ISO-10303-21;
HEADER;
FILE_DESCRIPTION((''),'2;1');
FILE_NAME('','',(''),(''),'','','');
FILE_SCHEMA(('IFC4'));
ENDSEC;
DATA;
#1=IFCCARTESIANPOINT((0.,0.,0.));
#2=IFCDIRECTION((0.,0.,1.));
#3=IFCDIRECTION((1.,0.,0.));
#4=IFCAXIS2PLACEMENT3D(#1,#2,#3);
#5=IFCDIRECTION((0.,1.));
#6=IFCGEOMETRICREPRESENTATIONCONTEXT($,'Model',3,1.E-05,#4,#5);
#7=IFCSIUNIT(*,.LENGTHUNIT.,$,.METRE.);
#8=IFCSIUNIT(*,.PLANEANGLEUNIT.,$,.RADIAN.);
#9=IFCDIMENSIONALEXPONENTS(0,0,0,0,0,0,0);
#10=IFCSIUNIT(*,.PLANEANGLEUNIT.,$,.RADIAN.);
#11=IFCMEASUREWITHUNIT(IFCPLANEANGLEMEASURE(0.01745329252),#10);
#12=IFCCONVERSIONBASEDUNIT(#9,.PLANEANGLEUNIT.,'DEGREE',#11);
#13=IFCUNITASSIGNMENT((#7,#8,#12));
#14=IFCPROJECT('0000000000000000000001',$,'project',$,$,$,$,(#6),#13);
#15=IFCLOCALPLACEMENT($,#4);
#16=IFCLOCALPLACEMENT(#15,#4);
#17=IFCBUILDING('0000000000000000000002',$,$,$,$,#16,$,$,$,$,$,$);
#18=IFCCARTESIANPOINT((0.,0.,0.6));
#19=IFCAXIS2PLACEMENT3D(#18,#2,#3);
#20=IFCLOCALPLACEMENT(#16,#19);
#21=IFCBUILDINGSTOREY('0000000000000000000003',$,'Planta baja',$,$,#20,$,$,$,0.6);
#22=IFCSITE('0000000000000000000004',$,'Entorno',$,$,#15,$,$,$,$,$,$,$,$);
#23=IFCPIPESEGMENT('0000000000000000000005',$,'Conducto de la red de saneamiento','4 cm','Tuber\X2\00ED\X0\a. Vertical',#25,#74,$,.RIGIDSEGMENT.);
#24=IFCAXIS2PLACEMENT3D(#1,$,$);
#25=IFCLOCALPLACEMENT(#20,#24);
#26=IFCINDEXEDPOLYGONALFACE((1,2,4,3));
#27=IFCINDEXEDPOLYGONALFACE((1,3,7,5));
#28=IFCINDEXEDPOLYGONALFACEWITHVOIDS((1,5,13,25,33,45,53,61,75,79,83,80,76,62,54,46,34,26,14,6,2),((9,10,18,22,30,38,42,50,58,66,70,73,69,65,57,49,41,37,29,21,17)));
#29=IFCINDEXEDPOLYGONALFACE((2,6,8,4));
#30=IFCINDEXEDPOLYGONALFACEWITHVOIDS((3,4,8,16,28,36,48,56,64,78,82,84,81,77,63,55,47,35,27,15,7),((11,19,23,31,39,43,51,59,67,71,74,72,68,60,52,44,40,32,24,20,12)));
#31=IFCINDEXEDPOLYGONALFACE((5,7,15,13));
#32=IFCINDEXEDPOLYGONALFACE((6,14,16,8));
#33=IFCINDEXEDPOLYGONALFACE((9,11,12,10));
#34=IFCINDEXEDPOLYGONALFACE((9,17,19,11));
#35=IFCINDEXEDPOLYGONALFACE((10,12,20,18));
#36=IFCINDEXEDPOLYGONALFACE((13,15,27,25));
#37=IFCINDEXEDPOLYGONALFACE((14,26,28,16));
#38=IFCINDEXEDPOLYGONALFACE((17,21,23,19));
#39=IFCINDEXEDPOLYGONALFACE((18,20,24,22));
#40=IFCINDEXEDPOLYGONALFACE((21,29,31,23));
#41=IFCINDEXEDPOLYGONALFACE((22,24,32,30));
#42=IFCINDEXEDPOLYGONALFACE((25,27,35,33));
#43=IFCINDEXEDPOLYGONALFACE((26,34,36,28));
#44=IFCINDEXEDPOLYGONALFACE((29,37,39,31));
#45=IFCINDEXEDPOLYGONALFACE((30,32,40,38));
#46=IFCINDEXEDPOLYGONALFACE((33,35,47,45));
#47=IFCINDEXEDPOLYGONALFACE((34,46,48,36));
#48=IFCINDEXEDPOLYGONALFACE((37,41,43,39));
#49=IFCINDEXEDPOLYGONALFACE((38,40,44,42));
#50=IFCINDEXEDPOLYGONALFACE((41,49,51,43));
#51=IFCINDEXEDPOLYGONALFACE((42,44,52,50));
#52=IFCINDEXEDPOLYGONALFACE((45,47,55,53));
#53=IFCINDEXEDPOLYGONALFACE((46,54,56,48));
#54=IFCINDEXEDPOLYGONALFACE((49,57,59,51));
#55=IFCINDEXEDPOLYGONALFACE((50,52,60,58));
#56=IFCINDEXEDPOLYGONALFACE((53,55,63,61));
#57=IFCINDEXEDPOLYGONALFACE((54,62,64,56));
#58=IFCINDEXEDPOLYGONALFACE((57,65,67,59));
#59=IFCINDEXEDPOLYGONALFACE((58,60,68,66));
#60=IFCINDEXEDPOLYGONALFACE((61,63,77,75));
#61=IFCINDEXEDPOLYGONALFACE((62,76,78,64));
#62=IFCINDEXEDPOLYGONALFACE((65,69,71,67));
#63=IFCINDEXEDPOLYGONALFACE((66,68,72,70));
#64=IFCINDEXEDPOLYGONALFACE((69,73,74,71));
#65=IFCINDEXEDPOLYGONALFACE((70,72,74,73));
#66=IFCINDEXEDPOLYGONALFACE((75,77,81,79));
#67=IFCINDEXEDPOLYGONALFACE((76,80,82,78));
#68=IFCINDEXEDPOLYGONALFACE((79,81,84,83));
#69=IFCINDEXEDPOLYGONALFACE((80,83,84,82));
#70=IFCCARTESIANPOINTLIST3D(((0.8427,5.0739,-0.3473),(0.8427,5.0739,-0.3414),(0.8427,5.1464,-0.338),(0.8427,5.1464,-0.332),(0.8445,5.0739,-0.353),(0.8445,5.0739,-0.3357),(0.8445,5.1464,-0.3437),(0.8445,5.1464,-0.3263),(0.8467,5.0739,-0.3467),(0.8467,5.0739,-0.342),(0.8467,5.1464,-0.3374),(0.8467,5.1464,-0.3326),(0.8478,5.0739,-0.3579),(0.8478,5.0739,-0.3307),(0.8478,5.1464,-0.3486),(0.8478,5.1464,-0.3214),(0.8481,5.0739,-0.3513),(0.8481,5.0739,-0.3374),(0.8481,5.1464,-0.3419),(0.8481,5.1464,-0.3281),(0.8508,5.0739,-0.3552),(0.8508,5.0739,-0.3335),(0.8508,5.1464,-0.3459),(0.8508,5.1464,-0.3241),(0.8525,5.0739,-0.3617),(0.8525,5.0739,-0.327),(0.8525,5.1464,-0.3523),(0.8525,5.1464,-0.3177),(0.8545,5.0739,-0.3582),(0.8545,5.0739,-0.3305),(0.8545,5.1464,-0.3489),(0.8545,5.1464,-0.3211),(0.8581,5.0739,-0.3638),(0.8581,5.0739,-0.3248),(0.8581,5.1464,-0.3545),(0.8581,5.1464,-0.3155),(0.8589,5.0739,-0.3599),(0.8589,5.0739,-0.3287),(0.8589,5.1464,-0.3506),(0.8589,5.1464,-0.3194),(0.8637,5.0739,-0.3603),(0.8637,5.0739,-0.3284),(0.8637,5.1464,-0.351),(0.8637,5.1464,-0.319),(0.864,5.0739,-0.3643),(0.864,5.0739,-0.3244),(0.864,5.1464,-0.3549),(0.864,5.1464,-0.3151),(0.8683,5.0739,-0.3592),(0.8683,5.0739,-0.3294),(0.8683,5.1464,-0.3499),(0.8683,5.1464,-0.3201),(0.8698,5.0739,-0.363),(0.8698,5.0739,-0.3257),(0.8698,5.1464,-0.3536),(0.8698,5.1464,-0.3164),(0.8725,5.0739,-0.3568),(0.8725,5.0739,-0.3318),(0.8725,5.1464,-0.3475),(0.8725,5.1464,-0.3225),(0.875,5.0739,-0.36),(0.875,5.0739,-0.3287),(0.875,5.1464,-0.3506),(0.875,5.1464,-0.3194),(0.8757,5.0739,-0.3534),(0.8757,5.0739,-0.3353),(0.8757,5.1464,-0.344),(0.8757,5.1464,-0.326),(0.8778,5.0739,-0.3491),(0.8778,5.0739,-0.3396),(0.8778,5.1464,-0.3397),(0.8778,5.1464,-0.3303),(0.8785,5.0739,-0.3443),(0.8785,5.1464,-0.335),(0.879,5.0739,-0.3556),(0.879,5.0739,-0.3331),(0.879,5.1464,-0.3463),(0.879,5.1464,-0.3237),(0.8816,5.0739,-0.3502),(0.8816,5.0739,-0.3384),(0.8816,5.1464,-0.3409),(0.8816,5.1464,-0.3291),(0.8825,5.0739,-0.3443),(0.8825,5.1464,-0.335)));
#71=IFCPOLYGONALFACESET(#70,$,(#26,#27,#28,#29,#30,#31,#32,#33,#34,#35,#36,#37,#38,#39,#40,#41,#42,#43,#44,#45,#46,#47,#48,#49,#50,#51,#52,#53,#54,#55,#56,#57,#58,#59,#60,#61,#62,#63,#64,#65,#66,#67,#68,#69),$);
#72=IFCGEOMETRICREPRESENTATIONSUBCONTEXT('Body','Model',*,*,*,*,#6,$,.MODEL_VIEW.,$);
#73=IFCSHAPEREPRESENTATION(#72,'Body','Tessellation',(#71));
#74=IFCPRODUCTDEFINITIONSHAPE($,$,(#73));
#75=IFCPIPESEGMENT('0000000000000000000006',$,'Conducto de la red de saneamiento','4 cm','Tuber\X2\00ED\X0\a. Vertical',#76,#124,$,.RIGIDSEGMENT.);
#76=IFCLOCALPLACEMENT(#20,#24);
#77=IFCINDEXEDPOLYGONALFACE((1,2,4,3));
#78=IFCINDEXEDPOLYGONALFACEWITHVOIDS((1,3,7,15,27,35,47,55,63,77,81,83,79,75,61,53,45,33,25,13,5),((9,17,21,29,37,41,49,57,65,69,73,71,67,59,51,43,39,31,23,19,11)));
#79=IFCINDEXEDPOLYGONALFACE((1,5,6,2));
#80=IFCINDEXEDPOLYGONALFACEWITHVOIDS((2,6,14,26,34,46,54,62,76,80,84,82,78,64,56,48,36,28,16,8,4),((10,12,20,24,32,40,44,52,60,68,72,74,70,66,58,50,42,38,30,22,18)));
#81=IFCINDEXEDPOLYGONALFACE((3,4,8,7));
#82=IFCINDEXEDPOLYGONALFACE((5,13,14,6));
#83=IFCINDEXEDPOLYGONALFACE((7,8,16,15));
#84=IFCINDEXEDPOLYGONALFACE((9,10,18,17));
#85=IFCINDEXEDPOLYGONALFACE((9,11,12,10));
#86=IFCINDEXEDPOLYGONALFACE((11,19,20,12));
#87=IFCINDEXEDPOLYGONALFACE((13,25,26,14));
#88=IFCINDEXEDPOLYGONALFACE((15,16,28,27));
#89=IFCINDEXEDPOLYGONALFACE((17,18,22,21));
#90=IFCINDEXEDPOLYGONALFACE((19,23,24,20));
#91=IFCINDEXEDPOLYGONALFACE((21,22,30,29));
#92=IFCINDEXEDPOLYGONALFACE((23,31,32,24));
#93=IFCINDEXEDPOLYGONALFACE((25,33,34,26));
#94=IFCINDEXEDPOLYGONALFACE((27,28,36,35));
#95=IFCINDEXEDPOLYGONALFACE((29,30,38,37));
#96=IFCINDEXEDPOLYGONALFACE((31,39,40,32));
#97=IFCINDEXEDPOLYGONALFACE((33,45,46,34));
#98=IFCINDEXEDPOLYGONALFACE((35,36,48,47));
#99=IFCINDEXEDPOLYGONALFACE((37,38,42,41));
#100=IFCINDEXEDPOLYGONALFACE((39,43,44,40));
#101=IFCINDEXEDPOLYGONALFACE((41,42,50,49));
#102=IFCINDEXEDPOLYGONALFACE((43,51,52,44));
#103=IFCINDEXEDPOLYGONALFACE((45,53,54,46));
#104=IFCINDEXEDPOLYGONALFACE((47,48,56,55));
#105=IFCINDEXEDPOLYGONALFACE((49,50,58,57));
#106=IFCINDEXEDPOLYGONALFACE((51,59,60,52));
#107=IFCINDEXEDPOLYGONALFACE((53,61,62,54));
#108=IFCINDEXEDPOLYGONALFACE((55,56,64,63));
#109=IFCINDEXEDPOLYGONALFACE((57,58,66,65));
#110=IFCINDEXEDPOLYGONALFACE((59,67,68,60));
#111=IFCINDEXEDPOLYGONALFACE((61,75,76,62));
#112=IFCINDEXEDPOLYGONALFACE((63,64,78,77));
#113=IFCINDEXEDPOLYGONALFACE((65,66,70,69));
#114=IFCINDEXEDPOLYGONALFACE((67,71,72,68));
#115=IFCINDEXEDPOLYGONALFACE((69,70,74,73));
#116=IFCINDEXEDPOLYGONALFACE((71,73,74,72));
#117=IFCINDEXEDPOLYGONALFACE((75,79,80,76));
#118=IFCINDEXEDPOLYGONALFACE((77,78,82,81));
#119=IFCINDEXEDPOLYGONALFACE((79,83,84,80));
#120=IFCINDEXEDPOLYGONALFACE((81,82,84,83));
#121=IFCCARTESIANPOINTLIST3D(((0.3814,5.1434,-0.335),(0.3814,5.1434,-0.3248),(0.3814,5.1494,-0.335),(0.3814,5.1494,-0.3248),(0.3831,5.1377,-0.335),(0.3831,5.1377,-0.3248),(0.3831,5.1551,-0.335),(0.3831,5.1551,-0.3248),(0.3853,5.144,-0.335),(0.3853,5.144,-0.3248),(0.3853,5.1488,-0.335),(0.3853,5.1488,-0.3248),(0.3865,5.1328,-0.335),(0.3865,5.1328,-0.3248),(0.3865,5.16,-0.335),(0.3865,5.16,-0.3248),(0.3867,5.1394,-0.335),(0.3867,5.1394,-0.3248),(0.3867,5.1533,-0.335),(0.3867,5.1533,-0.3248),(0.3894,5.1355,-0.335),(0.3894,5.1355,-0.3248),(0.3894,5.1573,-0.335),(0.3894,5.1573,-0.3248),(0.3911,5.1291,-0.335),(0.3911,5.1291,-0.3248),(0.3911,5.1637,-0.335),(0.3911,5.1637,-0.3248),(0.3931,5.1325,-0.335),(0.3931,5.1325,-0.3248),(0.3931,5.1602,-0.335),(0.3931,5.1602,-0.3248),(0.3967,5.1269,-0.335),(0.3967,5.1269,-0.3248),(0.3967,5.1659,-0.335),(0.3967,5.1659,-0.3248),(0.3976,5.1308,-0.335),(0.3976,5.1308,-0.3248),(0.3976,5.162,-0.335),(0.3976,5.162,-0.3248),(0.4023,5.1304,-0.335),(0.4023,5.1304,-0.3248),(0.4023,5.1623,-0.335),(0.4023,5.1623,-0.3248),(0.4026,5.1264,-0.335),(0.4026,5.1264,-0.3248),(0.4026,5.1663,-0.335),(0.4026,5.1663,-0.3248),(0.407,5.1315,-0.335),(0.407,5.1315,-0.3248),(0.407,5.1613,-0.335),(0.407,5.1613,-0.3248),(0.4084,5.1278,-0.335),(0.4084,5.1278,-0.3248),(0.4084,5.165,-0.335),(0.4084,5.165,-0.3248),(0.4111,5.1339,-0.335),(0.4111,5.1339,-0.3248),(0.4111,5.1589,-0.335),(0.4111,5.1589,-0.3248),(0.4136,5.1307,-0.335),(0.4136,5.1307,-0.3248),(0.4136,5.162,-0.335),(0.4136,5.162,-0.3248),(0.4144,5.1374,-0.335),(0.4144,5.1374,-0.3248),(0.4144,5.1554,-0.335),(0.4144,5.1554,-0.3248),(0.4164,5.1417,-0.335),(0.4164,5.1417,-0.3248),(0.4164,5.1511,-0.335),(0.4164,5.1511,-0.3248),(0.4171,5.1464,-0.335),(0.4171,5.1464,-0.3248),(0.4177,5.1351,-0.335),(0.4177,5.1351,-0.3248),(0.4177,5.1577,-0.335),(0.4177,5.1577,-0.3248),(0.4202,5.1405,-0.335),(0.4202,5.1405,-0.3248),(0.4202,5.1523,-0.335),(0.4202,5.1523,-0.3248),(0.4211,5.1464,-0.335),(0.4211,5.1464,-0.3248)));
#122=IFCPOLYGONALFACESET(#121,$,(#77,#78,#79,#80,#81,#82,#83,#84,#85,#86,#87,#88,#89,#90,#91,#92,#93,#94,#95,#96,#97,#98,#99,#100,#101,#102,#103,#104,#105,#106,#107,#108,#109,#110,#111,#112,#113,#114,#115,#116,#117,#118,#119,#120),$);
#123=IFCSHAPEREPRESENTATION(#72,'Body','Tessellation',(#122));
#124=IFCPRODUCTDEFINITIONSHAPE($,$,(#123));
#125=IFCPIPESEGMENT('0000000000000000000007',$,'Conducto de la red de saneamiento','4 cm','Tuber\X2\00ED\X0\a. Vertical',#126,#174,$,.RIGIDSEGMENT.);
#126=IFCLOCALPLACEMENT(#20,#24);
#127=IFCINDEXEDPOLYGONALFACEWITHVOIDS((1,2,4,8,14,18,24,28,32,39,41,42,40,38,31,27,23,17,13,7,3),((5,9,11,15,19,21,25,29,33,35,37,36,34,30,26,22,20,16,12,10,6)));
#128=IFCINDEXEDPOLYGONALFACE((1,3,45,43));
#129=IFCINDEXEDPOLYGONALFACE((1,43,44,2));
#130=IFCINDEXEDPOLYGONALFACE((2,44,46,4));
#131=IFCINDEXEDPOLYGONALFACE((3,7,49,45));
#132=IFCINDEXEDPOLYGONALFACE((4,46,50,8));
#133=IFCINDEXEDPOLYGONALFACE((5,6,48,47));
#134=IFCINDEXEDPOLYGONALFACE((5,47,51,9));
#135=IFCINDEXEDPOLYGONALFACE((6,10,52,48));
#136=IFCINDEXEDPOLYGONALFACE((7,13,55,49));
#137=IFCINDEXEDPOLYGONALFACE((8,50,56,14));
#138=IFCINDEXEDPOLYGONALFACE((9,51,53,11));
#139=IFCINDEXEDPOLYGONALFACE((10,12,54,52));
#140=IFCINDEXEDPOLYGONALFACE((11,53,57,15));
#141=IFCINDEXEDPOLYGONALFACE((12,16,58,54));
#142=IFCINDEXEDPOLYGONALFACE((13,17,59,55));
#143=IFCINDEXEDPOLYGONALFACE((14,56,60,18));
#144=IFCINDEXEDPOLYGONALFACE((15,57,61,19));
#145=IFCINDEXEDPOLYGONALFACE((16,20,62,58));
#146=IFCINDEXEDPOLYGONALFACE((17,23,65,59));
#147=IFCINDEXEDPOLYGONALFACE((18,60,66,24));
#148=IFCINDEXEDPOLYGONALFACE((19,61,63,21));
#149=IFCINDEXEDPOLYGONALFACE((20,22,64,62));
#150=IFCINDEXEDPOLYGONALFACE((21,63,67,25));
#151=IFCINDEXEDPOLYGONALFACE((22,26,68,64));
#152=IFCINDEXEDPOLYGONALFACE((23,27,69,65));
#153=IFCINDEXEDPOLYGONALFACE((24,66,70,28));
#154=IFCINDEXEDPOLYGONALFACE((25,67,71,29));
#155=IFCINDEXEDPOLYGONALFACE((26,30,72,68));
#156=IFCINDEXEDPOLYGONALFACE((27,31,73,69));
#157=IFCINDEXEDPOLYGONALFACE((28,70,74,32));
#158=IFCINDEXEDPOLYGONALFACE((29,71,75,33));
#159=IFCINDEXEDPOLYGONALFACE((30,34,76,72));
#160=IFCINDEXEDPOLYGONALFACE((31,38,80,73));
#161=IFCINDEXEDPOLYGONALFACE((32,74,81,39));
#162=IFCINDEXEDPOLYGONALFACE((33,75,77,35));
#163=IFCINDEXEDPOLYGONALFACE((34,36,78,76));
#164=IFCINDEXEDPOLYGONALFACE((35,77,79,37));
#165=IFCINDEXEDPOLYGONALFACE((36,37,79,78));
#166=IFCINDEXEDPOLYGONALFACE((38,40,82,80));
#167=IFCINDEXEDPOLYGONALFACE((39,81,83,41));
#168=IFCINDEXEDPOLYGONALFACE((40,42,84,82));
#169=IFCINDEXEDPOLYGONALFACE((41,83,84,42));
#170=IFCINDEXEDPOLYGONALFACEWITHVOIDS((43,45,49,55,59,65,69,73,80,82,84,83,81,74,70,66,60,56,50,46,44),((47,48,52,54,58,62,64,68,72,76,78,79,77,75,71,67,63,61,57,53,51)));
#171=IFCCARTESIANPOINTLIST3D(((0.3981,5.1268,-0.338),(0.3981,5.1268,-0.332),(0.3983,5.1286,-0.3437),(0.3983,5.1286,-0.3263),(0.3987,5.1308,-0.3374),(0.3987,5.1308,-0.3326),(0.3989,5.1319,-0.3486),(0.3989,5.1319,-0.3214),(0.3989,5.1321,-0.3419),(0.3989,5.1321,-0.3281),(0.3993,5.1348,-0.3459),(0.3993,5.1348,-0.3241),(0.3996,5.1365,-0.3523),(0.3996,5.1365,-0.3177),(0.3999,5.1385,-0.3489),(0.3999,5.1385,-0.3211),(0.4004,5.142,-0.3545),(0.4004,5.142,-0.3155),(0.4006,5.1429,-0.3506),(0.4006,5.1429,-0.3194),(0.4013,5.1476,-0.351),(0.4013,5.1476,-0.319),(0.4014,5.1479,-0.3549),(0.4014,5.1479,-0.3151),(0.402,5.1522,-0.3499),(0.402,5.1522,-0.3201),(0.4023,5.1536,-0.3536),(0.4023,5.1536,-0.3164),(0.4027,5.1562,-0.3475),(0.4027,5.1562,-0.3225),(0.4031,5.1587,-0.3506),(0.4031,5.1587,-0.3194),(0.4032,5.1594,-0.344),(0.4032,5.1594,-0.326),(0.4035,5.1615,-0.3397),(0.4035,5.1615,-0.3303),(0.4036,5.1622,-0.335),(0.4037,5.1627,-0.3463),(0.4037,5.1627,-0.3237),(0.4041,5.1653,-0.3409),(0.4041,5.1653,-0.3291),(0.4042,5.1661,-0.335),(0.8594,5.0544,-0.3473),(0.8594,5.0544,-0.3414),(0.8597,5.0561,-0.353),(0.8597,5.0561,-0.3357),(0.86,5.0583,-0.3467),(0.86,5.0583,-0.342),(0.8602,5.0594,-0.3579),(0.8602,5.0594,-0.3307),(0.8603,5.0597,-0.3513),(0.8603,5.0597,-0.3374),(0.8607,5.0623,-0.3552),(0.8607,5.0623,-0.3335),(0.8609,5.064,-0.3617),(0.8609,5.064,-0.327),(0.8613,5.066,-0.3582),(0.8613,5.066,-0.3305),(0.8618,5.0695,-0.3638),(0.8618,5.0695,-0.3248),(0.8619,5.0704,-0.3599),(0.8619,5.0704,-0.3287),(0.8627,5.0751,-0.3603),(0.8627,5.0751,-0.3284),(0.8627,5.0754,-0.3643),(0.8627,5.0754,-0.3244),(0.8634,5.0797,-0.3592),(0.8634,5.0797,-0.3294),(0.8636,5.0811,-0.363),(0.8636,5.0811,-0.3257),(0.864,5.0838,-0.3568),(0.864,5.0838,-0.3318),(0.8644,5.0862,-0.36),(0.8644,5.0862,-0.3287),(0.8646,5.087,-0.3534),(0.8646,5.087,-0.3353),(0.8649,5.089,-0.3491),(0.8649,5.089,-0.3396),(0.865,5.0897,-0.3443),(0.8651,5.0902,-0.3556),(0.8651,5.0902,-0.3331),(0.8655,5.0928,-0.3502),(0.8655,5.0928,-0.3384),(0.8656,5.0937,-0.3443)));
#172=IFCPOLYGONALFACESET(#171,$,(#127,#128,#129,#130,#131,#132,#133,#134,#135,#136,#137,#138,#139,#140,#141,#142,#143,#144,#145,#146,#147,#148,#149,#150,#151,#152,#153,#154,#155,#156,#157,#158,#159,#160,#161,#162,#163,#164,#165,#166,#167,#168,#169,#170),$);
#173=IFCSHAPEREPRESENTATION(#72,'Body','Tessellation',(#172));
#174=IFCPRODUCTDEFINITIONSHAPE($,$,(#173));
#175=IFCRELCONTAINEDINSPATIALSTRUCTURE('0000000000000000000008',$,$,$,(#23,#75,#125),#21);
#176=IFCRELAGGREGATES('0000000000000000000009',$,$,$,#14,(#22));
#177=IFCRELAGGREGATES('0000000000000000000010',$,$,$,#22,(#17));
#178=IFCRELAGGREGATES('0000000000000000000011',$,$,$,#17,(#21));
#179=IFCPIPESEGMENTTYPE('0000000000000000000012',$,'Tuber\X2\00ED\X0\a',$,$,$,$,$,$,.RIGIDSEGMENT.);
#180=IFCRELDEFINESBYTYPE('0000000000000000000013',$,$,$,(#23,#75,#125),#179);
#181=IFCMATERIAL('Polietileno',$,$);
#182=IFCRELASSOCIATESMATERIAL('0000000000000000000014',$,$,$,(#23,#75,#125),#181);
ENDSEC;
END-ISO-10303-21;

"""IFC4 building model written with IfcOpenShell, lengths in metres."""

from ifc_helpers import new_model, entity, si_unit, converted_unit, direction, frame, origin_with_axes, origin_2d_with_axis, place, context, subcontext, project, spatial, hollow_circle, extrude, material, type_object, element, save


model = new_model("IFC4")

# Units and contexts
model_context = context("Model", 3, precision=1e-05, world=origin_with_axes(), true_north=direction((0.0, 1.0)))
body_context = subcontext(model_context, "Body", "Model", "MODEL_VIEW")
ifc_project = project(units=[si_unit("LENGTHUNIT", "METRE"), si_unit("PLANEANGLEUNIT", "RADIAN"), converted_unit("PLANEANGLEUNIT", "DEGREE", entity("IfcPlaneAngleMeasure", 0.01745329252), si_unit("PLANEANGLEUNIT", "RADIAN"), dimensions=[0, 0, 0, 0, 0, 0, 0])], contexts=[model_context])

# Site, building, storey
site_placement = place(None, origin_with_axes())
site = spatial("IfcSite", under=ifc_project, at=site_placement, Name="Entorno")
building_placement = place(site_placement, origin_with_axes())
building = spatial("IfcBuilding", under=site, at=building_placement)
storey_placement = place(building_placement, frame((0.0, 0.0, 0.6), z_axis=(0.0, 0.0, 1.0), x_axis=(1.0, 0.0, 0.0)))
storey = spatial("IfcBuildingStorey", under=building, at=storey_placement, Name="Planta baja", Elevation=0.6)

# Pipe segments
ifc_material_1 = material(Name="Polietileno")
pipe_segment_type_1 = type_object("IfcPipeSegmentType", Name="Tubería", PredefinedType="RIGIDSEGMENT")
pipe_segment_1_placement = place(storey_placement, frame((0.8625, 5.1464, -0.335), z_axis=(0.0, -1.0, 0.0), x_axis=(1.0, 0.0, 0.0)))
element("IfcPipeSegment", 1, at=pipe_segment_1_placement, inside=storey, type_object=pipe_segment_type_1, material=ifc_material_1, Name="Conducto de la red de saneamiento", Description="4 cm", ObjectType="Tubería. Vertical", PredefinedType="RIGIDSEGMENT", context=body_context, shape_type="SweptSolid", body=[
    extrude(hollow_circle(Radius=0.02, WallThickness=0.004, at=origin_2d_with_axis()), origin_with_axes(), (0.0, -0.127827, 0.991796), 0.0731),
])
pipe_segment_2_placement = place(storey_placement, frame((0.4011, 5.1464, -0.335), z_axis=(0.0, 0.0, 1.0), x_axis=(1.0, 0.0, 0.0)))
element("IfcPipeSegment", 2, at=pipe_segment_2_placement, inside=storey, type_object=pipe_segment_type_1, material=ifc_material_1, Name="Conducto de la red de saneamiento", Description="4 cm", ObjectType="Tubería. Vertical", PredefinedType="RIGIDSEGMENT", context=body_context, shape_type="SweptSolid", body=[
    extrude(hollow_circle(Radius=0.02, WallThickness=0.004, at=origin_2d_with_axis()), origin_with_axes(), (0.0, 0.0, 1.0), 0.0103),
])
pipe_segment_3_placement = place(storey_placement, frame((0.4011, 5.1464, -0.335), z_axis=(0.987887, -0.155178, 0.0), x_axis=(0.155178, 0.987887, 0.0)))
element("IfcPipeSegment", 3, at=pipe_segment_3_placement, inside=storey, type_object=pipe_segment_type_1, material=ifc_material_1, Name="Conducto de la red de saneamiento", Description="4 cm", ObjectType="Tubería. Vertical", PredefinedType="RIGIDSEGMENT", context=body_context, shape_type="SweptSolid", body=[
    extrude(hollow_circle(Radius=0.02, WallThickness=0.004, at=origin_2d_with_axis()), origin_with_axes(), (0.0, -0.019996, 0.9998), 0.4671),
])

save(model, "model.ifc")
